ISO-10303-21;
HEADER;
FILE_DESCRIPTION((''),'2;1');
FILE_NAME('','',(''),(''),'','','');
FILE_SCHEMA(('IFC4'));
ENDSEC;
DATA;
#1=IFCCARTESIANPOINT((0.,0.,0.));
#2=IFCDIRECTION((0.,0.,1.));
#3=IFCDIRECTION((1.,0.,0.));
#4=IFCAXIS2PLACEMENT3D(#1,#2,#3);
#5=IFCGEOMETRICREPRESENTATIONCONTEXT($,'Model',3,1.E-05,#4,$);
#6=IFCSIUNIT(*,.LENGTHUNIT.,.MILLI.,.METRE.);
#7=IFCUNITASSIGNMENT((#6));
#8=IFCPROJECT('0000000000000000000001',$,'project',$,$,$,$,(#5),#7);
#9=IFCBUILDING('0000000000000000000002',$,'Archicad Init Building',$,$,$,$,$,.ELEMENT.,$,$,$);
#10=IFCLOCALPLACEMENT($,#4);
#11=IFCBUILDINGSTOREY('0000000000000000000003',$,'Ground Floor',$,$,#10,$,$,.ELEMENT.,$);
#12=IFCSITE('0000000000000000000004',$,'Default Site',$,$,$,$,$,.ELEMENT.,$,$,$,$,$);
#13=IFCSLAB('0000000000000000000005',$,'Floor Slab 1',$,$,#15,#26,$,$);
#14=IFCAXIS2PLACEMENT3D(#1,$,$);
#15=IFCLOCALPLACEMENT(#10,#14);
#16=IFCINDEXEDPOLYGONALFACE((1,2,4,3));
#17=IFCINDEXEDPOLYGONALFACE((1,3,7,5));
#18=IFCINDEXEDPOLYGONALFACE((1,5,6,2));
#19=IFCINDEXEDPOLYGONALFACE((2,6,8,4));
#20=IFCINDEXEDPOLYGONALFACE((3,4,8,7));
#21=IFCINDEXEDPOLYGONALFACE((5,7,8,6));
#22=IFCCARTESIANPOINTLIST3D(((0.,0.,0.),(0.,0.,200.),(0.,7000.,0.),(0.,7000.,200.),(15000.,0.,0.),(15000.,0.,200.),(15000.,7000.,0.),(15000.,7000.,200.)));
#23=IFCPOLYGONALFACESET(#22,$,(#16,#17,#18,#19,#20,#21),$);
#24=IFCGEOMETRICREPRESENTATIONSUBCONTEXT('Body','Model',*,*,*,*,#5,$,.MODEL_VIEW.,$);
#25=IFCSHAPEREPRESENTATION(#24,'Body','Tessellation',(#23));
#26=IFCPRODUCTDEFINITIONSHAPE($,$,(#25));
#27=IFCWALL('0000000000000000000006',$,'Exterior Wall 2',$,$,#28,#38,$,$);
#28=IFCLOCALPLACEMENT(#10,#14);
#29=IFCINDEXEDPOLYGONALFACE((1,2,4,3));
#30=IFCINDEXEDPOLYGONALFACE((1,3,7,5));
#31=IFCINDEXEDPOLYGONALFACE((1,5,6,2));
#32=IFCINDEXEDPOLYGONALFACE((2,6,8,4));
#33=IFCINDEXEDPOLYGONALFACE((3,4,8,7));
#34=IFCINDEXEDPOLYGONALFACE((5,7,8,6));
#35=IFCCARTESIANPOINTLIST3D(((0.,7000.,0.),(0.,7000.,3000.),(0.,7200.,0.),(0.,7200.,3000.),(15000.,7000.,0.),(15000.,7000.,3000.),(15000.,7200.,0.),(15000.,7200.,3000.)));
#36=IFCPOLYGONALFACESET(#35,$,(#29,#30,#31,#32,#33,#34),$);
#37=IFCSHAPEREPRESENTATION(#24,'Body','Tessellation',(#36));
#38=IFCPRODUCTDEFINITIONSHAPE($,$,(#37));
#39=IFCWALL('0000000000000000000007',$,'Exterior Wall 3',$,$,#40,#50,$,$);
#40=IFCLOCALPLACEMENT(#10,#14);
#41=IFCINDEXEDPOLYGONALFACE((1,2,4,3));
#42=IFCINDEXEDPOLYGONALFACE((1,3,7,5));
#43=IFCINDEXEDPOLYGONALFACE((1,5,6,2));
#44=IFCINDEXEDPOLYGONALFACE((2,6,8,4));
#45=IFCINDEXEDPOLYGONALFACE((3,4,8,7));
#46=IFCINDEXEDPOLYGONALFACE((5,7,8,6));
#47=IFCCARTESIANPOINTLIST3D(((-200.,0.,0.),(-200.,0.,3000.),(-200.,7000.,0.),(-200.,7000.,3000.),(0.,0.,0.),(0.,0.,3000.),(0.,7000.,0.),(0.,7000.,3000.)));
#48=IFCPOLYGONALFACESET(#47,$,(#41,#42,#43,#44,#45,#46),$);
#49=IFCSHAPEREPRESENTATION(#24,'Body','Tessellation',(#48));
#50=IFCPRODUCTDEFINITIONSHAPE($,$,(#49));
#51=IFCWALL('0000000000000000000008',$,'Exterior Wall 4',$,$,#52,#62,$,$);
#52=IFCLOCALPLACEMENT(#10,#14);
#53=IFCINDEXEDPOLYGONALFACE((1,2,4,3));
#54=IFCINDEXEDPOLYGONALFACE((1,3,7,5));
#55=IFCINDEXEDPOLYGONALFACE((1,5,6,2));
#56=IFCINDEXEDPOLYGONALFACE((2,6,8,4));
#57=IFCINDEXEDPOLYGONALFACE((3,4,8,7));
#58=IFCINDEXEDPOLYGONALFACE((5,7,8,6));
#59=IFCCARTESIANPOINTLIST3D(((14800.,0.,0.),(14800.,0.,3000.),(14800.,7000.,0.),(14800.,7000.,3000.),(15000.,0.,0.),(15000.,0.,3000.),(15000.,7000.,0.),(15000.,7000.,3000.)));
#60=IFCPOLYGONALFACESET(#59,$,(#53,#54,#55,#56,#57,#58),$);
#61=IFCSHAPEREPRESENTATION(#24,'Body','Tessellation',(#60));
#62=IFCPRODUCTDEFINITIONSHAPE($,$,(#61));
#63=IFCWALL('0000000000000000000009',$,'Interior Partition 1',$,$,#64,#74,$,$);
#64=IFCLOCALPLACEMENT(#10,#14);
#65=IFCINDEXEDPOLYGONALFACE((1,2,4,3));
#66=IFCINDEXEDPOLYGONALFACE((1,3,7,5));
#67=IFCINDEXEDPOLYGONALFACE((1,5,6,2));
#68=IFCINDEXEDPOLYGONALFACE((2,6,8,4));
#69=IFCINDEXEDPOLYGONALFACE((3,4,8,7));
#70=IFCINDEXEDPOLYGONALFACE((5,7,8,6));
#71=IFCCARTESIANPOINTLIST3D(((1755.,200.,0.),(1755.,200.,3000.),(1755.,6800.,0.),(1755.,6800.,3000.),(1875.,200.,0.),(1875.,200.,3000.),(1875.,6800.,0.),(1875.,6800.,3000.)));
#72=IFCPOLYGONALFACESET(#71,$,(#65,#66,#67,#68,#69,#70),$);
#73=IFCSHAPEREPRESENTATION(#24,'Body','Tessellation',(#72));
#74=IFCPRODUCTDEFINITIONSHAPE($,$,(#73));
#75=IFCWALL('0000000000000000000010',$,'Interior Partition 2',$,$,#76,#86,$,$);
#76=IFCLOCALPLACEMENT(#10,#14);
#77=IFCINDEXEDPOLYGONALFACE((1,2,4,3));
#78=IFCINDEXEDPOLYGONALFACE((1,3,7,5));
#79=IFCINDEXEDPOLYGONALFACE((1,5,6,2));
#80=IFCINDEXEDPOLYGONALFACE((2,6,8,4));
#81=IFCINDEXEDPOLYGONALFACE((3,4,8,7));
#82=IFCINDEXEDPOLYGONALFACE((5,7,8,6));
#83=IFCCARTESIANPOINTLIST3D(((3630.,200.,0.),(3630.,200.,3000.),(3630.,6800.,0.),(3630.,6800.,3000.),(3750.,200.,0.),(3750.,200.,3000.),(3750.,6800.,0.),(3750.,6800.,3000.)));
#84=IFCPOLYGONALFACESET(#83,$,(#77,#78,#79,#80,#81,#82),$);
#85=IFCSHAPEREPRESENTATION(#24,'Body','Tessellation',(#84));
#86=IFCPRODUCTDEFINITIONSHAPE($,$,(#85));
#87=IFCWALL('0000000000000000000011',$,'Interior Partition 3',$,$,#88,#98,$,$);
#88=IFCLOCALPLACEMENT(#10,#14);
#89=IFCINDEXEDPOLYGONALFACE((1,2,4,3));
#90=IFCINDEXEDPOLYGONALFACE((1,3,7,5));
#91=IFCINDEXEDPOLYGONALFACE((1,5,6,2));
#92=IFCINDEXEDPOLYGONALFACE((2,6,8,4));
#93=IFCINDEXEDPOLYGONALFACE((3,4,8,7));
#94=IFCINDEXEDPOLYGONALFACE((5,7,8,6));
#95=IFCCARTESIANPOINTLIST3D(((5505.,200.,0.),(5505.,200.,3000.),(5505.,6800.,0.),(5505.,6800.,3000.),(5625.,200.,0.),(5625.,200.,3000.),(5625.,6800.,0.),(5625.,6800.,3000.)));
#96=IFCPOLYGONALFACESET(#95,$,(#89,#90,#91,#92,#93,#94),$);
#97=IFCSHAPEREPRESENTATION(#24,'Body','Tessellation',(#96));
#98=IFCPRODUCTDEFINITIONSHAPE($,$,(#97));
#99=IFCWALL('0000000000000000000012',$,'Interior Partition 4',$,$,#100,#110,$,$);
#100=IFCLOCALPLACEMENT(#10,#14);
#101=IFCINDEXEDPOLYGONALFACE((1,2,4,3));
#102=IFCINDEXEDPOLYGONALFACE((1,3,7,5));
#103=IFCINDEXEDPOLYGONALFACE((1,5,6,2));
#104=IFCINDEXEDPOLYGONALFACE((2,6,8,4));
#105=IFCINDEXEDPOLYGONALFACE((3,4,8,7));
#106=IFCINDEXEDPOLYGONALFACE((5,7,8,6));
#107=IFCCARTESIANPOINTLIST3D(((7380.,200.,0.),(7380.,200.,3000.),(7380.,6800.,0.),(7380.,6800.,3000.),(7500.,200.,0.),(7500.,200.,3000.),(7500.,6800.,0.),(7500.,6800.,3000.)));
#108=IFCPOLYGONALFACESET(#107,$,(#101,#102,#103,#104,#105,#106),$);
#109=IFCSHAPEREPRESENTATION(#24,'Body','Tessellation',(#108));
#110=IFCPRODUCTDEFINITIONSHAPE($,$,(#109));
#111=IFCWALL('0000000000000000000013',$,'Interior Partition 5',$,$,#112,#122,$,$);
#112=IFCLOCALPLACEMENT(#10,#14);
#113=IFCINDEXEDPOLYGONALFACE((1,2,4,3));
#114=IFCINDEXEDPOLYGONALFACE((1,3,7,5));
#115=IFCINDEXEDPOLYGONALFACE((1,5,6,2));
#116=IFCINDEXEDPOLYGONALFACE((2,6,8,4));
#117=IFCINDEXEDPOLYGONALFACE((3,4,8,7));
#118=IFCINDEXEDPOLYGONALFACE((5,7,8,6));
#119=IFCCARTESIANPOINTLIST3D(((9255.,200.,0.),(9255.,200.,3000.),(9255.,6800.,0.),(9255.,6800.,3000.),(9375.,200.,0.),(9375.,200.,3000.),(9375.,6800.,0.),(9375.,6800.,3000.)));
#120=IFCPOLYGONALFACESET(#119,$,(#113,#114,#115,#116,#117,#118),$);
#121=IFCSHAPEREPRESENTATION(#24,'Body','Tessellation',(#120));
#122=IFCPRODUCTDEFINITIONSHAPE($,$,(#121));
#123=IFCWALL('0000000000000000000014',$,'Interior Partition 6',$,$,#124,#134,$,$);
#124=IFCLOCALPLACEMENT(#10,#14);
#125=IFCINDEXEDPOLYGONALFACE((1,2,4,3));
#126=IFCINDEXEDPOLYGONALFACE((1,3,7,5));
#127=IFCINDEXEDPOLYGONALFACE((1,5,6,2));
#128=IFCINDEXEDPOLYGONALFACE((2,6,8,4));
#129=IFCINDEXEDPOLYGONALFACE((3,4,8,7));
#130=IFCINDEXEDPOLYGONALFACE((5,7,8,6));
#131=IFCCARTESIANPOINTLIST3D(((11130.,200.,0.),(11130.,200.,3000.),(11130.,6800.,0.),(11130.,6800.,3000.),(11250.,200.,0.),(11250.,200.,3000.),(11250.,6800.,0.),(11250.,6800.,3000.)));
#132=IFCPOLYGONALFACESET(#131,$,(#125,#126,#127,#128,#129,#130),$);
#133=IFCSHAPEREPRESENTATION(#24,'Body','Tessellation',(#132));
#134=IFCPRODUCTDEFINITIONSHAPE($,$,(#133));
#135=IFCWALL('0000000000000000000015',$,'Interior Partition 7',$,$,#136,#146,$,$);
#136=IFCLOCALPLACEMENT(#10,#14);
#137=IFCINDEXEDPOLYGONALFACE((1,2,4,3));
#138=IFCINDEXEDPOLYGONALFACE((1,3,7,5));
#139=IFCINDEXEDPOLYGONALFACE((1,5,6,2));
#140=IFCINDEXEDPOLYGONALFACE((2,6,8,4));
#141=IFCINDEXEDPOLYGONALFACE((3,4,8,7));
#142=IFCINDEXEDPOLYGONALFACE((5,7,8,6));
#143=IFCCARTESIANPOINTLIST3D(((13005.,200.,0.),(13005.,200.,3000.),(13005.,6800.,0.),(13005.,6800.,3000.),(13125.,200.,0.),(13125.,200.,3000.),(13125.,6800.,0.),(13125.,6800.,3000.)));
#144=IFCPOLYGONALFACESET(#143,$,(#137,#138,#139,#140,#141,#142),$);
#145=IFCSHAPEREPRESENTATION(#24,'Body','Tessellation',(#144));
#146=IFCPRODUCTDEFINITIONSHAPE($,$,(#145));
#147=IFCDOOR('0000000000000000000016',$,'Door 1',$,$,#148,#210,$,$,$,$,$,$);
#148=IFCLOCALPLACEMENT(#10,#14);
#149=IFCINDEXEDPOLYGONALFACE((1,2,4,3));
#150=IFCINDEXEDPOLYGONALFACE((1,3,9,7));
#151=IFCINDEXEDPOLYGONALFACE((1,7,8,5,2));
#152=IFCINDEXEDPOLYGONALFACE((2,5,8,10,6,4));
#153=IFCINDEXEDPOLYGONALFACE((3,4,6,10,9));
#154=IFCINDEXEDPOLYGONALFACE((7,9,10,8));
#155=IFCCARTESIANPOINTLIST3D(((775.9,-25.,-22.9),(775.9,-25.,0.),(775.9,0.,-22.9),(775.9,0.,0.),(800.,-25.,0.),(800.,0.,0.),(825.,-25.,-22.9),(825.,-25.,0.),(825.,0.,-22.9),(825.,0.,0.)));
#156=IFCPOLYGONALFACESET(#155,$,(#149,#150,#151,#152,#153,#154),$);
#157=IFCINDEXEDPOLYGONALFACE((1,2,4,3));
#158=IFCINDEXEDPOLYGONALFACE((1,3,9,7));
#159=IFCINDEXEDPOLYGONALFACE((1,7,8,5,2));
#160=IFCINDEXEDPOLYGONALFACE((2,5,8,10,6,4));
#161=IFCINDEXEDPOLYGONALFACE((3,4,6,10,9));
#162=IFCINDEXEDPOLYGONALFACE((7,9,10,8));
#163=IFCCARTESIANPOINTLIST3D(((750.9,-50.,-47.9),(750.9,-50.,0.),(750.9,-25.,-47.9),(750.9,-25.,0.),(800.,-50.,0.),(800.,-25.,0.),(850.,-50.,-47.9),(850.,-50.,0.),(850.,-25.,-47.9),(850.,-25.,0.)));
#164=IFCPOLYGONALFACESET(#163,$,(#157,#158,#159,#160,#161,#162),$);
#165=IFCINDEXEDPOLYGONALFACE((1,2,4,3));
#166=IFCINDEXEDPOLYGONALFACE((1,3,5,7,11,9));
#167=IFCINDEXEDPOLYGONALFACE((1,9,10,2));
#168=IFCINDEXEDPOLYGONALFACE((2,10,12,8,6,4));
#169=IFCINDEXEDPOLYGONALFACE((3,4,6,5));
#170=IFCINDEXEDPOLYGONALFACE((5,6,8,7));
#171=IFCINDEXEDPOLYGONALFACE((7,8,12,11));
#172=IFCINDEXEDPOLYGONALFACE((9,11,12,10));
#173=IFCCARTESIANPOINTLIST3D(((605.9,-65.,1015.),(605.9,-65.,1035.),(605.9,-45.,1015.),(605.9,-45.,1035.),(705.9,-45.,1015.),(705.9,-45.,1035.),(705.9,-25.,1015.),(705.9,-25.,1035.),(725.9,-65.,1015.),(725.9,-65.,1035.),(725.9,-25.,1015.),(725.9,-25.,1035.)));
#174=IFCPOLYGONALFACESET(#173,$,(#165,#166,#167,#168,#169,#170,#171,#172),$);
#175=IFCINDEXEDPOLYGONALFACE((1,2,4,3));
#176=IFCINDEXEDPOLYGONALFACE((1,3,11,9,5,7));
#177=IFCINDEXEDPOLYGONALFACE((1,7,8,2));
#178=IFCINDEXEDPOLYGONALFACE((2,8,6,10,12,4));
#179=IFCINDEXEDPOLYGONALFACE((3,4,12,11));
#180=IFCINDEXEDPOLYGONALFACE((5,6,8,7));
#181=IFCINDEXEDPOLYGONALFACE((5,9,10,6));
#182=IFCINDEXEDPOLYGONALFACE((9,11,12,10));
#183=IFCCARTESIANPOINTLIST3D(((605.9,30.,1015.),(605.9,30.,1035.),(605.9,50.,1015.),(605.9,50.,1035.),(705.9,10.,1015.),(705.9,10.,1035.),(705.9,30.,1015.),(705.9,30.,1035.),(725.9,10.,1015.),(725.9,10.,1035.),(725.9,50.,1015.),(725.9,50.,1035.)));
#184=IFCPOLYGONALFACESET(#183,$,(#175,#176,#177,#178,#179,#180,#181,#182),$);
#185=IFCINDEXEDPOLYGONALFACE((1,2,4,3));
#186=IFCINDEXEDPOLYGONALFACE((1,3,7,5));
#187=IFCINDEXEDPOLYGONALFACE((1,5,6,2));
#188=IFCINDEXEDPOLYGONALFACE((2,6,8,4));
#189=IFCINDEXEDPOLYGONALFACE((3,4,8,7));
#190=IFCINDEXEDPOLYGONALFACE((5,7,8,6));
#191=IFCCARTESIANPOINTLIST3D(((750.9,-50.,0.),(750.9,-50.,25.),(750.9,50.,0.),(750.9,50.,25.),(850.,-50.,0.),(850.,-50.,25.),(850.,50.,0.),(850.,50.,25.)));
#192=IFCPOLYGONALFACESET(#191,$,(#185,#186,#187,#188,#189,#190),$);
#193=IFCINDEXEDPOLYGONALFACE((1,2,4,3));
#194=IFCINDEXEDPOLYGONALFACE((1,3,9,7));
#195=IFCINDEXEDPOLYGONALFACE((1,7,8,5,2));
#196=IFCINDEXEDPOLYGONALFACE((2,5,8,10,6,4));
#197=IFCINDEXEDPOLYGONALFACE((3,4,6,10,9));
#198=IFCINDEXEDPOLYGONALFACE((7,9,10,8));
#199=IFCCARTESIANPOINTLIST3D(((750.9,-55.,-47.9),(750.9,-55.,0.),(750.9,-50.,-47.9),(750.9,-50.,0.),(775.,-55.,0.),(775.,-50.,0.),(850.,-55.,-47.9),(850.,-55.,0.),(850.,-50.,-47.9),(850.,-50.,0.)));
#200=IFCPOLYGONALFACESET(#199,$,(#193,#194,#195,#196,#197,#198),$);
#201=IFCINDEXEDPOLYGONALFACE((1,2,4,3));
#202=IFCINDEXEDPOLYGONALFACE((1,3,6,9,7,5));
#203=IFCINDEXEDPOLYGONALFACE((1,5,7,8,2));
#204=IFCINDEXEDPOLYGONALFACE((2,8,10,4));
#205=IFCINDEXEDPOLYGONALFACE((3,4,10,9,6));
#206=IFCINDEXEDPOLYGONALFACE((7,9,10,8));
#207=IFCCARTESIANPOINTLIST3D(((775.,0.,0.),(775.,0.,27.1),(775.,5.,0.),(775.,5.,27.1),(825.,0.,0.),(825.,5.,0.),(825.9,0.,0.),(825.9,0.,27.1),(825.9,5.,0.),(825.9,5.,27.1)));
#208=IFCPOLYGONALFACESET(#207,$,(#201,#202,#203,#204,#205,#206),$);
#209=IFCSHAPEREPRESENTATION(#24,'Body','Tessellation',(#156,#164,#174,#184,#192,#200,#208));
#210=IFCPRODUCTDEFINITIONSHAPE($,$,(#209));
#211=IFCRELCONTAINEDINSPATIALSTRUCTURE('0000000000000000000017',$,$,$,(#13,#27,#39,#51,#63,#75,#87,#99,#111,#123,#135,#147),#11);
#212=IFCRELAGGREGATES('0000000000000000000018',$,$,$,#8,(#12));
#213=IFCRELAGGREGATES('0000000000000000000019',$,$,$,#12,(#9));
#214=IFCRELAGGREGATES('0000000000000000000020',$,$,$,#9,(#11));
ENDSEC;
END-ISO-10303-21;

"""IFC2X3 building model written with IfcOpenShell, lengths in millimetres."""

from ifc_helpers import new_model, si_unit, frame, origin_with_axes, place, context, subcontext, project, spatial, polyline, outline, extrude, element, save


model = new_model("IFC2X3")

# Units and contexts
model_context = context("Model", 3, precision=1e-05, world=origin_with_axes())
body_context = subcontext(model_context, "Body", "Model", "MODEL_VIEW")
ifc_project = project(units=[si_unit("LENGTHUNIT", "METRE", prefix="MILLI")], contexts=[model_context])

# Site, building, storey
site = spatial("IfcSite", under=ifc_project, Name="Default Site", CompositionType="ELEMENT")
building = spatial("IfcBuilding", under=site, Name="Archicad Init Building", CompositionType="ELEMENT")
storey_placement = place(None, origin_with_axes())
storey = spatial("IfcBuildingStorey", under=building, at=storey_placement, Name="Ground Floor", CompositionType="ELEMENT")

# Slab
slab_placement = place(storey_placement, origin_with_axes())
element("IfcSlab", 1, at=slab_placement, inside=storey, Name="Floor Slab 1", context=body_context, shape_type="SweptSolid", body=[
    extrude(outline(polyline([(0.0, 0.0), (15000.0, 0.0), (15000.0, 7000.0), (0.0, 7000.0), (0.0, 0.0)])), origin_with_axes(), (0.0, 0.0, 1.0), 200.0),
])

# Walls
wall_placement = place(storey_placement, frame((0.0, 7000.0, 0.0), z_axis=(0.0, 0.0, 1.0), x_axis=(1.0, 0.0, 0.0)))
element("IfcWall", 2, at=wall_placement, inside=storey, Name="Exterior Wall 2", context=body_context, shape_type="SweptSolid", body=[
    extrude(outline(polyline([(0.0, 0.0), (0.0, 200.0), (15000.0, 200.0), (15000.0, 0.0), (0.0, 0.0)])), origin_with_axes(), (0.0, 0.0, 1.0), 3000.0),
])
for number, where, z_axis, x_axis, name in (
    (3, (0.0, 0.0, 0.0), (0.0, 0.0, 1.0), (0.0, 1.0, 0.0), "Exterior Wall 3"),
    (4, (15000.0, 0.0, 0.0), (0.0, 0.0, 1.0), (0.0, 1.0, 0.0), "Exterior Wall 4"),
):
    element("IfcWall", number, at=place(storey_placement, frame(where, z_axis=z_axis, x_axis=x_axis)), inside=storey, Name=name, context=body_context, shape_type="SweptSolid", body=[
        extrude(outline(polyline([(0.0, 0.0), (0.0, 200.0), (7000.0, 200.0), (7000.0, 0.0), (0.0, 0.0)])), origin_with_axes(), (0.0, 0.0, 1.0), 3000.0),
    ])
for number, where, z_axis, x_axis, name in (
    (5, (1875.0, 200.0, 0.0), (0.0, 0.0, 1.0), (0.0, 1.0, 0.0), "Interior Partition 1"),
    (6, (3750.0, 200.0, 0.0), (0.0, 0.0, 1.0), (0.0, 1.0, 0.0), "Interior Partition 2"),
    (7, (5625.0, 200.0, 0.0), (0.0, 0.0, 1.0), (0.0, 1.0, 0.0), "Interior Partition 3"),
    (8, (7500.0, 200.0, 0.0), (0.0, 0.0, 1.0), (0.0, 1.0, 0.0), "Interior Partition 4"),
    (9, (9375.0, 200.0, 0.0), (0.0, 0.0, 1.0), (0.0, 1.0, 0.0), "Interior Partition 5"),
    (10, (11250.0, 200.0, 0.0), (0.0, 0.0, 1.0), (0.0, 1.0, 0.0), "Interior Partition 6"),
    (11, (13125.0, 200.0, 0.0), (0.0, 0.0, 1.0), (0.0, 1.0, 0.0), "Interior Partition 7"),
):
    element("IfcWall", number, at=place(storey_placement, frame(where, z_axis=z_axis, x_axis=x_axis)), inside=storey, Name=name, context=body_context, shape_type="SweptSolid", body=[
        extrude(outline(polyline([(0.0, 0.0), (0.0, 120.0), (6600.0, 120.0), (6600.0, 0.0), (0.0, 0.0)])), origin_with_axes(), (0.0, 0.0, 1.0), 3000.0),
    ])

# Door
door_1_placement = place(storey_placement, frame((800.0, -50.0, 0.0), z_axis=(0.0, 0.0, 1.0), x_axis=(1.0, 0.0, 0.0)))
element("IfcDoor", 12, at=door_1_placement, inside=storey, Name="Door 1", context=body_context, shape_type="SweptSolid", body=[
    extrude(outline(polyline([(0.0, 0.0), (0.0, 2.1), (0.9, 2.1), (0.9, 0.0), (-24.1, 0.0), (-24.1, -22.9), (25.0, -22.9), (25.0, 0.0), (0.0, 0.0)])), frame((0.0, 25.0, 0.0), z_axis=(0.0, -1.0, 0.0), x_axis=(1.0, 0.0, 0.0)), (0.0, 0.0, -1.0), 25.0),
    extrude(outline(polyline([(0.0, 0.0), (0.0, 2.1), (0.9, 2.1), (0.9, 0.0), (-49.1, 0.0), (-49.1, -47.9), (50.0, -47.9), (50.0, 0.0), (0.0, 0.0)])), frame((0.0, 0.0, 0.0), z_axis=(0.0, -1.0, 0.0), x_axis=(1.0, 0.0, 0.0)), (0.0, 0.0, -1.0), 25.0),
    extrude(outline(polyline([(0.0, 0.0), (-49.1, 0.0), (-49.1, 35.0), (0.0, 35.0), (0.0, 0.0)])), frame((25.0, 25.0, 25.0), z_axis=(0.0, 0.0, 1.0), x_axis=(1.0, 0.0, 0.0)), (0.0, 0.0, 1.0), -47.9),
    extrude(outline(polyline([(0.0, 0.0), (0.0, -40.0), (-120.0, -40.0), (-120.0, -20.0), (-20.0, -20.0), (-20.0, 0.0), (0.0, 0.0)])), frame((-74.1, 25.0, 1015.0), z_axis=(0.0, 0.0, 1.0), x_axis=(1.0, 0.0, 0.0)), (0.0, 0.0, 1.0), 20.0),
    extrude(outline(polyline([(0.0, 0.0), (0.0, 40.0), (-120.0, 40.0), (-120.0, 20.0), (-20.0, 20.0), (-20.0, 0.0), (0.0, 0.0)])), frame((-74.1, 60.0, 1015.0), z_axis=(0.0, 0.0, 1.0), x_axis=(1.0, 0.0, 0.0)), (0.0, 0.0, 1.0), 20.0),
    extrude(outline(polyline([(0.0, 0.0), (-99.1, 0.0), (-99.1, 100.0), (0.0, 100.0), (0.0, 0.0)])), frame((50.0, 0.0, 0.0), z_axis=(0.0, 0.0, 1.0), x_axis=(1.0, 0.0, 0.0)), (0.0, 0.0, 1.0), 25.0),
    extrude(outline(polyline([(0.0, 0.0), (0.0, 27.1), (50.9, 27.1), (50.9, 0.0), (-24.1, 0.0), (-24.1, -47.9), (75.0, -47.9), (75.0, 0.0), (0.0, 0.0)])), frame((-25.0, -5.0, 0.0), z_axis=(0.0, -1.0, 0.0), x_axis=(1.0, 0.0, 0.0)), (0.0, 0.0, -1.0), 5.0),
    extrude(outline(polyline([(0.0, 0.0), (0.0, 27.1), (50.9, 27.1), (50.9, 0.0), (0.9, 0.0), (0.9, -22.9), (50.0, -22.9), (50.0, 0.0), (0.0, 0.0)])), frame((-25.0, 50.0, 0.0), z_axis=(0.0, -1.0, 0.0), x_axis=(1.0, 0.0, 0.0)), (0.0, 0.0, -1.0), 5.0),
])

save(model, "model.ifc")
